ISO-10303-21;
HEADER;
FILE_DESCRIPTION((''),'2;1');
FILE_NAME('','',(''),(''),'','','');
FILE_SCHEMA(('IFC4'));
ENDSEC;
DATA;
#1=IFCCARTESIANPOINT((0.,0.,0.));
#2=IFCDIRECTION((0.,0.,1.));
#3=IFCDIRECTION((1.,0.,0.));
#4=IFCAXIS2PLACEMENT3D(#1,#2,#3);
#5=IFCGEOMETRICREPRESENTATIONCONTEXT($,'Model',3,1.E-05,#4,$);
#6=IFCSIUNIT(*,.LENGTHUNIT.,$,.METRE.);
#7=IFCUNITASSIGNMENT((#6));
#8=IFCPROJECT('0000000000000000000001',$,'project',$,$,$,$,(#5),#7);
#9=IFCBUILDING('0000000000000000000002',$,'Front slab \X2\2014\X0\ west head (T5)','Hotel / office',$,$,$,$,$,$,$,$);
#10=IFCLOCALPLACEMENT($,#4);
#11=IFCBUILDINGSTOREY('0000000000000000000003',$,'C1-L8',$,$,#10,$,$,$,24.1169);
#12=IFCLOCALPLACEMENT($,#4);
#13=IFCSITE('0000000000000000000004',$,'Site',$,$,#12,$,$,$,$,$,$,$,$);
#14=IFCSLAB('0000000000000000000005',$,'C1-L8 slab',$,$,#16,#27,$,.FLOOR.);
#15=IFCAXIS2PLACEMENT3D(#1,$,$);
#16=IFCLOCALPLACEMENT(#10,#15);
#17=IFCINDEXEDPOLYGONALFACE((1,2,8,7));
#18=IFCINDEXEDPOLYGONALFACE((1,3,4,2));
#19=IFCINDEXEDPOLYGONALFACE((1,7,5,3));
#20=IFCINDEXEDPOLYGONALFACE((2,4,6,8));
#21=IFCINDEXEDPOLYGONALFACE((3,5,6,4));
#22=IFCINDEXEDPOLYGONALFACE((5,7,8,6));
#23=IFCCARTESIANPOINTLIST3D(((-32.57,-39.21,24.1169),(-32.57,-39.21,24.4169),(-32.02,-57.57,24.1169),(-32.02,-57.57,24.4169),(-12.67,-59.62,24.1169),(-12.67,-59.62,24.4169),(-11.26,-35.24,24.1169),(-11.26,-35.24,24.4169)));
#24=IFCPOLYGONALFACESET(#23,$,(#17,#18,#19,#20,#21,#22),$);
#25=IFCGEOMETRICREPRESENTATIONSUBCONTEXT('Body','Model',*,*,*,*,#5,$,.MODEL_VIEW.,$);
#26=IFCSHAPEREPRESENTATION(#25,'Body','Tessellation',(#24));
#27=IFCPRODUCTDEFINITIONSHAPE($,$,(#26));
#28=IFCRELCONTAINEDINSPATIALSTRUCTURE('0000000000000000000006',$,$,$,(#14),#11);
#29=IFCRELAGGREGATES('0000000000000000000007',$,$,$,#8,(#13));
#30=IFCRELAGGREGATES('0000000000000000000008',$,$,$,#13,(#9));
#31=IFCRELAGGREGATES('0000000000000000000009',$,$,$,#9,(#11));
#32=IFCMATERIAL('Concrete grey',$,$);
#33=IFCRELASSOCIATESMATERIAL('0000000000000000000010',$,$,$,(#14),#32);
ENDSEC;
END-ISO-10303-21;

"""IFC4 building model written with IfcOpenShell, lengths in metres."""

from ifc_helpers import new_model, si_unit, frame, origin_with_axes, place, context, subcontext, project, spatial, polyline, outline, extrude, material, element, save


model = new_model("IFC4")

# Units and contexts
model_context = context("Model", 3, precision=1e-05, world=origin_with_axes())
body_context = subcontext(model_context, "Body", "Model", "MODEL_VIEW")
ifc_project = project(units=[si_unit("LENGTHUNIT", "METRE")], contexts=[model_context])

# Site, building, storey
site_placement = place(None, origin_with_axes())
site = spatial("IfcSite", under=ifc_project, at=site_placement, Name="Site")
building = spatial("IfcBuilding", under=site, Name="Front slab — west head (T5)", Description="Hotel / office")
storey_placement = place(None, origin_with_axes())
storey = spatial("IfcBuildingStorey", under=building, at=storey_placement, Name="C1-L8", Elevation=24.1169)

# Slab
ifc_material_1 = material(Name="Concrete grey")
slab_placement = place(storey_placement, origin_with_axes())
element("IfcSlab", 1, at=slab_placement, inside=storey, material=ifc_material_1, Name="C1-L8 slab", PredefinedType="FLOOR", context=body_context, shape_type="SweptSolid", body=[
    extrude(outline(polyline([(-32.57, -39.21), (-32.02, -57.57), (-12.67, -59.62), (-11.26, -35.24), (-32.57, -39.21)])), frame((0.0, 0.0, 24.1169), z_axis=(0.0, 0.0, 1.0), x_axis=(1.0, 0.0, 0.0)), (0.0, 0.0, 1.0), 0.3),
])

save(model, "model.ifc")
